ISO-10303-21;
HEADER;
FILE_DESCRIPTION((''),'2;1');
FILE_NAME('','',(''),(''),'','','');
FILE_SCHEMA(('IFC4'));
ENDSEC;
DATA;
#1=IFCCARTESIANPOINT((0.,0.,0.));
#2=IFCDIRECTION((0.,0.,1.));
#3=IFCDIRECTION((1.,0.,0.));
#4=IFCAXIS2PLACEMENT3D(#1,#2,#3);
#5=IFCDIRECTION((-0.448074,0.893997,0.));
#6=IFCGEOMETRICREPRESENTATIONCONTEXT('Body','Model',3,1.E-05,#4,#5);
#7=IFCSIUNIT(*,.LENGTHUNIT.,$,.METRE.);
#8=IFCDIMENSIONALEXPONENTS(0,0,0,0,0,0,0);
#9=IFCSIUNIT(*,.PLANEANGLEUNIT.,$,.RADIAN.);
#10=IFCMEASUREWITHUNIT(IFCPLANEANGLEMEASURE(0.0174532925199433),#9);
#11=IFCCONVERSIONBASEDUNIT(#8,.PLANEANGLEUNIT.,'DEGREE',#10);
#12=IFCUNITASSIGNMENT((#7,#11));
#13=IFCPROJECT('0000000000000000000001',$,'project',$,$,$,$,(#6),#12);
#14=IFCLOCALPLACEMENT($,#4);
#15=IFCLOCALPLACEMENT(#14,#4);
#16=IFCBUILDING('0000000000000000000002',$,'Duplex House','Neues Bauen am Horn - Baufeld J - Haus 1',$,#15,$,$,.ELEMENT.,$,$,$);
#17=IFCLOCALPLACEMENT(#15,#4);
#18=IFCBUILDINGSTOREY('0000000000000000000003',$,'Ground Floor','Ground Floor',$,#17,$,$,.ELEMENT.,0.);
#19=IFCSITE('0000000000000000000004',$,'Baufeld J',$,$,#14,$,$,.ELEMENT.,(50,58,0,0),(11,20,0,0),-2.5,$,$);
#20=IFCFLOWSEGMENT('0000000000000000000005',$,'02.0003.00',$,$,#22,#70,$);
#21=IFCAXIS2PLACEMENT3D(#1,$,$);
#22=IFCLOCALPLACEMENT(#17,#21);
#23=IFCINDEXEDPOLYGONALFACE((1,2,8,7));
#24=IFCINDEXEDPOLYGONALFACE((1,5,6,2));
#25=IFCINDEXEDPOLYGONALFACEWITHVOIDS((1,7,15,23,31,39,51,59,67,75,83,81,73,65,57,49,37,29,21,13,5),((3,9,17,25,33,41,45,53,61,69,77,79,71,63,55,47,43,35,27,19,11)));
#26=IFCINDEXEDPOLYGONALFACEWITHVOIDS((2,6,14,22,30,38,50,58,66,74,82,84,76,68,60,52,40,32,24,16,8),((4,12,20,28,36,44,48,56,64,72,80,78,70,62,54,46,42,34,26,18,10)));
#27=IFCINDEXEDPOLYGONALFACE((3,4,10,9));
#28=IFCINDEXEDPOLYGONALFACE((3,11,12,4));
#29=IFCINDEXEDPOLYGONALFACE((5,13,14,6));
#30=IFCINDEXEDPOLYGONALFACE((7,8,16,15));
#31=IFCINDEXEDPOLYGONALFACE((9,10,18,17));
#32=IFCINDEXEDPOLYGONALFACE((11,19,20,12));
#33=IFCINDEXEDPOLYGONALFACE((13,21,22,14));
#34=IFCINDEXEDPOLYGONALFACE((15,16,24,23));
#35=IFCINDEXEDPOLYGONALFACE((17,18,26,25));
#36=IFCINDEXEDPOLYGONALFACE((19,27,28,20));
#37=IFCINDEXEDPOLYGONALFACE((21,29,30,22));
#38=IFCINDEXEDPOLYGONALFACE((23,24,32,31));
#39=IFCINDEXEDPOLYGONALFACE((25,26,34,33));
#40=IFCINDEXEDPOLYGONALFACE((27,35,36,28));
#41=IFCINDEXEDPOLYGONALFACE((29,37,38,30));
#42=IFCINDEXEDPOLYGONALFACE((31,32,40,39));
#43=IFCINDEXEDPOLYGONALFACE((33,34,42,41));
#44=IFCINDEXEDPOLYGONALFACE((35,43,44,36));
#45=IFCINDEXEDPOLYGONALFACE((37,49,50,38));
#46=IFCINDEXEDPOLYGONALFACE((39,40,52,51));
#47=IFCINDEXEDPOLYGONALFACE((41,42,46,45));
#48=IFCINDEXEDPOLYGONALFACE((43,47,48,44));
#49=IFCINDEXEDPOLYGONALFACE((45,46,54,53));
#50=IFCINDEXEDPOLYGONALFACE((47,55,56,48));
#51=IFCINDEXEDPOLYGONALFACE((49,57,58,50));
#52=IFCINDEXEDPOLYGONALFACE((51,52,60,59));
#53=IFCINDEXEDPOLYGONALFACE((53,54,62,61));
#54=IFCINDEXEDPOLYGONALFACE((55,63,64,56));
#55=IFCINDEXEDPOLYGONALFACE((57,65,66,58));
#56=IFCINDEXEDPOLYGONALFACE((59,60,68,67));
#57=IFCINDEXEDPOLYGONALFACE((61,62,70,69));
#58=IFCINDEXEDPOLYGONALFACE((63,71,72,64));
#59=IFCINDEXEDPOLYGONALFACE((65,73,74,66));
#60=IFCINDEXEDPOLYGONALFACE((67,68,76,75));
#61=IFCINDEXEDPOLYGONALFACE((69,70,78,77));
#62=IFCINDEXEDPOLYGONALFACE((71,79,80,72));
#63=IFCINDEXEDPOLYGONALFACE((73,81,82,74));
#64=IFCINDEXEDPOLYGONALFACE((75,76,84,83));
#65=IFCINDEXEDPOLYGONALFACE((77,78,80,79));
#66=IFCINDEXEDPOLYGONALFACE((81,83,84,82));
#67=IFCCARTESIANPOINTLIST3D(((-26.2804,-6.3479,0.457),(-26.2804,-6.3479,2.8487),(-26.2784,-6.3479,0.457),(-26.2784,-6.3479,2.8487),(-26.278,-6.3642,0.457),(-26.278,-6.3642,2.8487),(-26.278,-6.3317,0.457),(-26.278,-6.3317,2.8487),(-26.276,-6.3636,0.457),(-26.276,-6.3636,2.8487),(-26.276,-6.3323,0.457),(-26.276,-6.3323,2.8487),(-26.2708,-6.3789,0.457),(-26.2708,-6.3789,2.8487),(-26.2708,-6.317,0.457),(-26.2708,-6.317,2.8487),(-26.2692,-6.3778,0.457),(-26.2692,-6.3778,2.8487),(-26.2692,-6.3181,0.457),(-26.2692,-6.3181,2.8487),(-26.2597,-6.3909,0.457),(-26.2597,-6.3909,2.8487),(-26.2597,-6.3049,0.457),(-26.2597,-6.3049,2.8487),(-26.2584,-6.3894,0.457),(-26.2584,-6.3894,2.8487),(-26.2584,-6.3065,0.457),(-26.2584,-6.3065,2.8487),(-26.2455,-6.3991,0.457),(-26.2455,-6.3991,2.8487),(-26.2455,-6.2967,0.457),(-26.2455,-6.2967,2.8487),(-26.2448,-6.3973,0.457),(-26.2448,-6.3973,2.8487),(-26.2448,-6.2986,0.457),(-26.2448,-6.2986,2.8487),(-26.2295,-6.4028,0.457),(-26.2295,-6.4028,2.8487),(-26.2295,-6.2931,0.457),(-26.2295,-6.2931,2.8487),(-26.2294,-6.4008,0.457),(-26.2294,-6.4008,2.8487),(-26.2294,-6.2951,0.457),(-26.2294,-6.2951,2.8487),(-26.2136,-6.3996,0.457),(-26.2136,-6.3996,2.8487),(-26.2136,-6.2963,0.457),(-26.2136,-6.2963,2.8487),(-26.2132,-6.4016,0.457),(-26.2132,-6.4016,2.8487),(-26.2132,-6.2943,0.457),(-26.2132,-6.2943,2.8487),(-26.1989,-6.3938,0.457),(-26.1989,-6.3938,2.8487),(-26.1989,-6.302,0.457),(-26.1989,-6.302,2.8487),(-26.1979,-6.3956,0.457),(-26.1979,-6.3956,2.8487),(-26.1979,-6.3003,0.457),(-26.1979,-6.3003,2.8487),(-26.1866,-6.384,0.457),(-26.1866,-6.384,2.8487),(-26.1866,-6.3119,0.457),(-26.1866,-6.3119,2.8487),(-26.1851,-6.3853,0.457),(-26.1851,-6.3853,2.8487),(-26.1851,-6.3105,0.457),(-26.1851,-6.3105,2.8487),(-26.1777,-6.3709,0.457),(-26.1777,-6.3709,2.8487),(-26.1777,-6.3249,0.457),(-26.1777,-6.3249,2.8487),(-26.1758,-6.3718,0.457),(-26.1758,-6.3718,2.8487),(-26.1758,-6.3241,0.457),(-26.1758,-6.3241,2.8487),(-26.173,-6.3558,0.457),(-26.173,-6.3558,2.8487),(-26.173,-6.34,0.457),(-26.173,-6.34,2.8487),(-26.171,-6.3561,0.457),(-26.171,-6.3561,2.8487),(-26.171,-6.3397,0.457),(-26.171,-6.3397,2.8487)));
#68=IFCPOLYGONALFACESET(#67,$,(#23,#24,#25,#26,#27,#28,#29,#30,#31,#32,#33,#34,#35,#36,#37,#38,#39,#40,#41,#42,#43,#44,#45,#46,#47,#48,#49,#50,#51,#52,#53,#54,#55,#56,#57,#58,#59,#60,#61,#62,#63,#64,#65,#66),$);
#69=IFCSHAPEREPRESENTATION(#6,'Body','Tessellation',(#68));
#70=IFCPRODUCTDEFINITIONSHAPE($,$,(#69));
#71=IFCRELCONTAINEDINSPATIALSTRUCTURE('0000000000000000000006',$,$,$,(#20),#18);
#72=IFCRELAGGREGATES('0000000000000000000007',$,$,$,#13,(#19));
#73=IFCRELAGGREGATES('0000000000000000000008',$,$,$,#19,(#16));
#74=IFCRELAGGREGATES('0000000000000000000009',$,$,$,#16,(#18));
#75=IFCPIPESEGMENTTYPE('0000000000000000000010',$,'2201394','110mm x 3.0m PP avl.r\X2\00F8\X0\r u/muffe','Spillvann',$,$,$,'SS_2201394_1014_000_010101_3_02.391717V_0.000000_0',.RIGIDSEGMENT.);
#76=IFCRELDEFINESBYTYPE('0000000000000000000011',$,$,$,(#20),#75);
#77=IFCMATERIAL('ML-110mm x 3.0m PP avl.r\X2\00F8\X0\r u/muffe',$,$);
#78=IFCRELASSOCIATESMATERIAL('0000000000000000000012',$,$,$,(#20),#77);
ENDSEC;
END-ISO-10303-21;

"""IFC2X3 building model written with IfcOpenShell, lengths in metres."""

from ifc_helpers import new_model, entity, si_unit, converted_unit, direction, frame, origin_with_axes, origin_2d_with_axis, place, context, project, spatial, hollow_circle, extrude, material, type_object, element, save


model = new_model("IFC2X3")

# Units and contexts
model_context = context("Model", 3, precision=1e-05, world=origin_with_axes(), true_north=direction((-0.448074, 0.893997, 0.0)), identifier="Body")
ifc_project = project(units=[si_unit("LENGTHUNIT", "METRE"), converted_unit("PLANEANGLEUNIT", "DEGREE", entity("IfcPlaneAngleMeasure", 0.0174532925199433), si_unit("PLANEANGLEUNIT", "RADIAN"), dimensions=[0, 0, 0, 0, 0, 0, 0])], contexts=[model_context])

# Site, building, storey
site_placement = place(None, origin_with_axes())
site = spatial("IfcSite", under=ifc_project, at=site_placement, Name="Baufeld J", CompositionType="ELEMENT", RefLatitude=(50, 58, 0, 0), RefLongitude=(11, 20, 0, 0), RefElevation=-2.5)
building_placement = place(site_placement, origin_with_axes())
building = spatial("IfcBuilding", under=site, at=building_placement, Name="Duplex House", Description="Neues Bauen am Horn - Baufeld J - Haus 1", CompositionType="ELEMENT")
storey_placement = place(building_placement, origin_with_axes())
storey = spatial("IfcBuildingStorey", under=building, at=storey_placement, Name="Ground Floor", Description="Ground Floor", CompositionType="ELEMENT", Elevation=0.0)

# Flow segment
ifc_material_1 = material(Name="ML-110mm x 3.0m PP avl.rør u/muffe")
pipe_segment_type_1 = type_object("IfcPipeSegmentType", Name="2201394", Description="110mm x 3.0m PP avl.rør u/muffe", ApplicableOccurrence="Spillvann", ElementType="SS_2201394_1014_000_010101_3_02.391717V_0.000000_0", PredefinedType="RIGIDSEGMENT")
flow_segment_1_placement = place(storey_placement, frame((-26.2254, -6.3479, 2.8487), z_axis=(1.0, 0.0, 0.0), x_axis=(0.0, 0.0, -1.0)))
element("IfcFlowSegment", 1, at=flow_segment_1_placement, inside=storey, type_object=pipe_segment_type_1, material=ifc_material_1, Name="02.0003.00", context=model_context, shape_type="SweptSolid", body=[
    extrude(hollow_circle(Radius=0.055, WallThickness=0.002, at=origin_2d_with_axis()), frame((0.0, 0.0, 0.0), z_axis=(1.0, 0.0, 0.0), x_axis=(0.0, 0.0, -1.0)), (0.0, 0.0, 1.0), 2.3917),
])

save(model, "model.ifc")
